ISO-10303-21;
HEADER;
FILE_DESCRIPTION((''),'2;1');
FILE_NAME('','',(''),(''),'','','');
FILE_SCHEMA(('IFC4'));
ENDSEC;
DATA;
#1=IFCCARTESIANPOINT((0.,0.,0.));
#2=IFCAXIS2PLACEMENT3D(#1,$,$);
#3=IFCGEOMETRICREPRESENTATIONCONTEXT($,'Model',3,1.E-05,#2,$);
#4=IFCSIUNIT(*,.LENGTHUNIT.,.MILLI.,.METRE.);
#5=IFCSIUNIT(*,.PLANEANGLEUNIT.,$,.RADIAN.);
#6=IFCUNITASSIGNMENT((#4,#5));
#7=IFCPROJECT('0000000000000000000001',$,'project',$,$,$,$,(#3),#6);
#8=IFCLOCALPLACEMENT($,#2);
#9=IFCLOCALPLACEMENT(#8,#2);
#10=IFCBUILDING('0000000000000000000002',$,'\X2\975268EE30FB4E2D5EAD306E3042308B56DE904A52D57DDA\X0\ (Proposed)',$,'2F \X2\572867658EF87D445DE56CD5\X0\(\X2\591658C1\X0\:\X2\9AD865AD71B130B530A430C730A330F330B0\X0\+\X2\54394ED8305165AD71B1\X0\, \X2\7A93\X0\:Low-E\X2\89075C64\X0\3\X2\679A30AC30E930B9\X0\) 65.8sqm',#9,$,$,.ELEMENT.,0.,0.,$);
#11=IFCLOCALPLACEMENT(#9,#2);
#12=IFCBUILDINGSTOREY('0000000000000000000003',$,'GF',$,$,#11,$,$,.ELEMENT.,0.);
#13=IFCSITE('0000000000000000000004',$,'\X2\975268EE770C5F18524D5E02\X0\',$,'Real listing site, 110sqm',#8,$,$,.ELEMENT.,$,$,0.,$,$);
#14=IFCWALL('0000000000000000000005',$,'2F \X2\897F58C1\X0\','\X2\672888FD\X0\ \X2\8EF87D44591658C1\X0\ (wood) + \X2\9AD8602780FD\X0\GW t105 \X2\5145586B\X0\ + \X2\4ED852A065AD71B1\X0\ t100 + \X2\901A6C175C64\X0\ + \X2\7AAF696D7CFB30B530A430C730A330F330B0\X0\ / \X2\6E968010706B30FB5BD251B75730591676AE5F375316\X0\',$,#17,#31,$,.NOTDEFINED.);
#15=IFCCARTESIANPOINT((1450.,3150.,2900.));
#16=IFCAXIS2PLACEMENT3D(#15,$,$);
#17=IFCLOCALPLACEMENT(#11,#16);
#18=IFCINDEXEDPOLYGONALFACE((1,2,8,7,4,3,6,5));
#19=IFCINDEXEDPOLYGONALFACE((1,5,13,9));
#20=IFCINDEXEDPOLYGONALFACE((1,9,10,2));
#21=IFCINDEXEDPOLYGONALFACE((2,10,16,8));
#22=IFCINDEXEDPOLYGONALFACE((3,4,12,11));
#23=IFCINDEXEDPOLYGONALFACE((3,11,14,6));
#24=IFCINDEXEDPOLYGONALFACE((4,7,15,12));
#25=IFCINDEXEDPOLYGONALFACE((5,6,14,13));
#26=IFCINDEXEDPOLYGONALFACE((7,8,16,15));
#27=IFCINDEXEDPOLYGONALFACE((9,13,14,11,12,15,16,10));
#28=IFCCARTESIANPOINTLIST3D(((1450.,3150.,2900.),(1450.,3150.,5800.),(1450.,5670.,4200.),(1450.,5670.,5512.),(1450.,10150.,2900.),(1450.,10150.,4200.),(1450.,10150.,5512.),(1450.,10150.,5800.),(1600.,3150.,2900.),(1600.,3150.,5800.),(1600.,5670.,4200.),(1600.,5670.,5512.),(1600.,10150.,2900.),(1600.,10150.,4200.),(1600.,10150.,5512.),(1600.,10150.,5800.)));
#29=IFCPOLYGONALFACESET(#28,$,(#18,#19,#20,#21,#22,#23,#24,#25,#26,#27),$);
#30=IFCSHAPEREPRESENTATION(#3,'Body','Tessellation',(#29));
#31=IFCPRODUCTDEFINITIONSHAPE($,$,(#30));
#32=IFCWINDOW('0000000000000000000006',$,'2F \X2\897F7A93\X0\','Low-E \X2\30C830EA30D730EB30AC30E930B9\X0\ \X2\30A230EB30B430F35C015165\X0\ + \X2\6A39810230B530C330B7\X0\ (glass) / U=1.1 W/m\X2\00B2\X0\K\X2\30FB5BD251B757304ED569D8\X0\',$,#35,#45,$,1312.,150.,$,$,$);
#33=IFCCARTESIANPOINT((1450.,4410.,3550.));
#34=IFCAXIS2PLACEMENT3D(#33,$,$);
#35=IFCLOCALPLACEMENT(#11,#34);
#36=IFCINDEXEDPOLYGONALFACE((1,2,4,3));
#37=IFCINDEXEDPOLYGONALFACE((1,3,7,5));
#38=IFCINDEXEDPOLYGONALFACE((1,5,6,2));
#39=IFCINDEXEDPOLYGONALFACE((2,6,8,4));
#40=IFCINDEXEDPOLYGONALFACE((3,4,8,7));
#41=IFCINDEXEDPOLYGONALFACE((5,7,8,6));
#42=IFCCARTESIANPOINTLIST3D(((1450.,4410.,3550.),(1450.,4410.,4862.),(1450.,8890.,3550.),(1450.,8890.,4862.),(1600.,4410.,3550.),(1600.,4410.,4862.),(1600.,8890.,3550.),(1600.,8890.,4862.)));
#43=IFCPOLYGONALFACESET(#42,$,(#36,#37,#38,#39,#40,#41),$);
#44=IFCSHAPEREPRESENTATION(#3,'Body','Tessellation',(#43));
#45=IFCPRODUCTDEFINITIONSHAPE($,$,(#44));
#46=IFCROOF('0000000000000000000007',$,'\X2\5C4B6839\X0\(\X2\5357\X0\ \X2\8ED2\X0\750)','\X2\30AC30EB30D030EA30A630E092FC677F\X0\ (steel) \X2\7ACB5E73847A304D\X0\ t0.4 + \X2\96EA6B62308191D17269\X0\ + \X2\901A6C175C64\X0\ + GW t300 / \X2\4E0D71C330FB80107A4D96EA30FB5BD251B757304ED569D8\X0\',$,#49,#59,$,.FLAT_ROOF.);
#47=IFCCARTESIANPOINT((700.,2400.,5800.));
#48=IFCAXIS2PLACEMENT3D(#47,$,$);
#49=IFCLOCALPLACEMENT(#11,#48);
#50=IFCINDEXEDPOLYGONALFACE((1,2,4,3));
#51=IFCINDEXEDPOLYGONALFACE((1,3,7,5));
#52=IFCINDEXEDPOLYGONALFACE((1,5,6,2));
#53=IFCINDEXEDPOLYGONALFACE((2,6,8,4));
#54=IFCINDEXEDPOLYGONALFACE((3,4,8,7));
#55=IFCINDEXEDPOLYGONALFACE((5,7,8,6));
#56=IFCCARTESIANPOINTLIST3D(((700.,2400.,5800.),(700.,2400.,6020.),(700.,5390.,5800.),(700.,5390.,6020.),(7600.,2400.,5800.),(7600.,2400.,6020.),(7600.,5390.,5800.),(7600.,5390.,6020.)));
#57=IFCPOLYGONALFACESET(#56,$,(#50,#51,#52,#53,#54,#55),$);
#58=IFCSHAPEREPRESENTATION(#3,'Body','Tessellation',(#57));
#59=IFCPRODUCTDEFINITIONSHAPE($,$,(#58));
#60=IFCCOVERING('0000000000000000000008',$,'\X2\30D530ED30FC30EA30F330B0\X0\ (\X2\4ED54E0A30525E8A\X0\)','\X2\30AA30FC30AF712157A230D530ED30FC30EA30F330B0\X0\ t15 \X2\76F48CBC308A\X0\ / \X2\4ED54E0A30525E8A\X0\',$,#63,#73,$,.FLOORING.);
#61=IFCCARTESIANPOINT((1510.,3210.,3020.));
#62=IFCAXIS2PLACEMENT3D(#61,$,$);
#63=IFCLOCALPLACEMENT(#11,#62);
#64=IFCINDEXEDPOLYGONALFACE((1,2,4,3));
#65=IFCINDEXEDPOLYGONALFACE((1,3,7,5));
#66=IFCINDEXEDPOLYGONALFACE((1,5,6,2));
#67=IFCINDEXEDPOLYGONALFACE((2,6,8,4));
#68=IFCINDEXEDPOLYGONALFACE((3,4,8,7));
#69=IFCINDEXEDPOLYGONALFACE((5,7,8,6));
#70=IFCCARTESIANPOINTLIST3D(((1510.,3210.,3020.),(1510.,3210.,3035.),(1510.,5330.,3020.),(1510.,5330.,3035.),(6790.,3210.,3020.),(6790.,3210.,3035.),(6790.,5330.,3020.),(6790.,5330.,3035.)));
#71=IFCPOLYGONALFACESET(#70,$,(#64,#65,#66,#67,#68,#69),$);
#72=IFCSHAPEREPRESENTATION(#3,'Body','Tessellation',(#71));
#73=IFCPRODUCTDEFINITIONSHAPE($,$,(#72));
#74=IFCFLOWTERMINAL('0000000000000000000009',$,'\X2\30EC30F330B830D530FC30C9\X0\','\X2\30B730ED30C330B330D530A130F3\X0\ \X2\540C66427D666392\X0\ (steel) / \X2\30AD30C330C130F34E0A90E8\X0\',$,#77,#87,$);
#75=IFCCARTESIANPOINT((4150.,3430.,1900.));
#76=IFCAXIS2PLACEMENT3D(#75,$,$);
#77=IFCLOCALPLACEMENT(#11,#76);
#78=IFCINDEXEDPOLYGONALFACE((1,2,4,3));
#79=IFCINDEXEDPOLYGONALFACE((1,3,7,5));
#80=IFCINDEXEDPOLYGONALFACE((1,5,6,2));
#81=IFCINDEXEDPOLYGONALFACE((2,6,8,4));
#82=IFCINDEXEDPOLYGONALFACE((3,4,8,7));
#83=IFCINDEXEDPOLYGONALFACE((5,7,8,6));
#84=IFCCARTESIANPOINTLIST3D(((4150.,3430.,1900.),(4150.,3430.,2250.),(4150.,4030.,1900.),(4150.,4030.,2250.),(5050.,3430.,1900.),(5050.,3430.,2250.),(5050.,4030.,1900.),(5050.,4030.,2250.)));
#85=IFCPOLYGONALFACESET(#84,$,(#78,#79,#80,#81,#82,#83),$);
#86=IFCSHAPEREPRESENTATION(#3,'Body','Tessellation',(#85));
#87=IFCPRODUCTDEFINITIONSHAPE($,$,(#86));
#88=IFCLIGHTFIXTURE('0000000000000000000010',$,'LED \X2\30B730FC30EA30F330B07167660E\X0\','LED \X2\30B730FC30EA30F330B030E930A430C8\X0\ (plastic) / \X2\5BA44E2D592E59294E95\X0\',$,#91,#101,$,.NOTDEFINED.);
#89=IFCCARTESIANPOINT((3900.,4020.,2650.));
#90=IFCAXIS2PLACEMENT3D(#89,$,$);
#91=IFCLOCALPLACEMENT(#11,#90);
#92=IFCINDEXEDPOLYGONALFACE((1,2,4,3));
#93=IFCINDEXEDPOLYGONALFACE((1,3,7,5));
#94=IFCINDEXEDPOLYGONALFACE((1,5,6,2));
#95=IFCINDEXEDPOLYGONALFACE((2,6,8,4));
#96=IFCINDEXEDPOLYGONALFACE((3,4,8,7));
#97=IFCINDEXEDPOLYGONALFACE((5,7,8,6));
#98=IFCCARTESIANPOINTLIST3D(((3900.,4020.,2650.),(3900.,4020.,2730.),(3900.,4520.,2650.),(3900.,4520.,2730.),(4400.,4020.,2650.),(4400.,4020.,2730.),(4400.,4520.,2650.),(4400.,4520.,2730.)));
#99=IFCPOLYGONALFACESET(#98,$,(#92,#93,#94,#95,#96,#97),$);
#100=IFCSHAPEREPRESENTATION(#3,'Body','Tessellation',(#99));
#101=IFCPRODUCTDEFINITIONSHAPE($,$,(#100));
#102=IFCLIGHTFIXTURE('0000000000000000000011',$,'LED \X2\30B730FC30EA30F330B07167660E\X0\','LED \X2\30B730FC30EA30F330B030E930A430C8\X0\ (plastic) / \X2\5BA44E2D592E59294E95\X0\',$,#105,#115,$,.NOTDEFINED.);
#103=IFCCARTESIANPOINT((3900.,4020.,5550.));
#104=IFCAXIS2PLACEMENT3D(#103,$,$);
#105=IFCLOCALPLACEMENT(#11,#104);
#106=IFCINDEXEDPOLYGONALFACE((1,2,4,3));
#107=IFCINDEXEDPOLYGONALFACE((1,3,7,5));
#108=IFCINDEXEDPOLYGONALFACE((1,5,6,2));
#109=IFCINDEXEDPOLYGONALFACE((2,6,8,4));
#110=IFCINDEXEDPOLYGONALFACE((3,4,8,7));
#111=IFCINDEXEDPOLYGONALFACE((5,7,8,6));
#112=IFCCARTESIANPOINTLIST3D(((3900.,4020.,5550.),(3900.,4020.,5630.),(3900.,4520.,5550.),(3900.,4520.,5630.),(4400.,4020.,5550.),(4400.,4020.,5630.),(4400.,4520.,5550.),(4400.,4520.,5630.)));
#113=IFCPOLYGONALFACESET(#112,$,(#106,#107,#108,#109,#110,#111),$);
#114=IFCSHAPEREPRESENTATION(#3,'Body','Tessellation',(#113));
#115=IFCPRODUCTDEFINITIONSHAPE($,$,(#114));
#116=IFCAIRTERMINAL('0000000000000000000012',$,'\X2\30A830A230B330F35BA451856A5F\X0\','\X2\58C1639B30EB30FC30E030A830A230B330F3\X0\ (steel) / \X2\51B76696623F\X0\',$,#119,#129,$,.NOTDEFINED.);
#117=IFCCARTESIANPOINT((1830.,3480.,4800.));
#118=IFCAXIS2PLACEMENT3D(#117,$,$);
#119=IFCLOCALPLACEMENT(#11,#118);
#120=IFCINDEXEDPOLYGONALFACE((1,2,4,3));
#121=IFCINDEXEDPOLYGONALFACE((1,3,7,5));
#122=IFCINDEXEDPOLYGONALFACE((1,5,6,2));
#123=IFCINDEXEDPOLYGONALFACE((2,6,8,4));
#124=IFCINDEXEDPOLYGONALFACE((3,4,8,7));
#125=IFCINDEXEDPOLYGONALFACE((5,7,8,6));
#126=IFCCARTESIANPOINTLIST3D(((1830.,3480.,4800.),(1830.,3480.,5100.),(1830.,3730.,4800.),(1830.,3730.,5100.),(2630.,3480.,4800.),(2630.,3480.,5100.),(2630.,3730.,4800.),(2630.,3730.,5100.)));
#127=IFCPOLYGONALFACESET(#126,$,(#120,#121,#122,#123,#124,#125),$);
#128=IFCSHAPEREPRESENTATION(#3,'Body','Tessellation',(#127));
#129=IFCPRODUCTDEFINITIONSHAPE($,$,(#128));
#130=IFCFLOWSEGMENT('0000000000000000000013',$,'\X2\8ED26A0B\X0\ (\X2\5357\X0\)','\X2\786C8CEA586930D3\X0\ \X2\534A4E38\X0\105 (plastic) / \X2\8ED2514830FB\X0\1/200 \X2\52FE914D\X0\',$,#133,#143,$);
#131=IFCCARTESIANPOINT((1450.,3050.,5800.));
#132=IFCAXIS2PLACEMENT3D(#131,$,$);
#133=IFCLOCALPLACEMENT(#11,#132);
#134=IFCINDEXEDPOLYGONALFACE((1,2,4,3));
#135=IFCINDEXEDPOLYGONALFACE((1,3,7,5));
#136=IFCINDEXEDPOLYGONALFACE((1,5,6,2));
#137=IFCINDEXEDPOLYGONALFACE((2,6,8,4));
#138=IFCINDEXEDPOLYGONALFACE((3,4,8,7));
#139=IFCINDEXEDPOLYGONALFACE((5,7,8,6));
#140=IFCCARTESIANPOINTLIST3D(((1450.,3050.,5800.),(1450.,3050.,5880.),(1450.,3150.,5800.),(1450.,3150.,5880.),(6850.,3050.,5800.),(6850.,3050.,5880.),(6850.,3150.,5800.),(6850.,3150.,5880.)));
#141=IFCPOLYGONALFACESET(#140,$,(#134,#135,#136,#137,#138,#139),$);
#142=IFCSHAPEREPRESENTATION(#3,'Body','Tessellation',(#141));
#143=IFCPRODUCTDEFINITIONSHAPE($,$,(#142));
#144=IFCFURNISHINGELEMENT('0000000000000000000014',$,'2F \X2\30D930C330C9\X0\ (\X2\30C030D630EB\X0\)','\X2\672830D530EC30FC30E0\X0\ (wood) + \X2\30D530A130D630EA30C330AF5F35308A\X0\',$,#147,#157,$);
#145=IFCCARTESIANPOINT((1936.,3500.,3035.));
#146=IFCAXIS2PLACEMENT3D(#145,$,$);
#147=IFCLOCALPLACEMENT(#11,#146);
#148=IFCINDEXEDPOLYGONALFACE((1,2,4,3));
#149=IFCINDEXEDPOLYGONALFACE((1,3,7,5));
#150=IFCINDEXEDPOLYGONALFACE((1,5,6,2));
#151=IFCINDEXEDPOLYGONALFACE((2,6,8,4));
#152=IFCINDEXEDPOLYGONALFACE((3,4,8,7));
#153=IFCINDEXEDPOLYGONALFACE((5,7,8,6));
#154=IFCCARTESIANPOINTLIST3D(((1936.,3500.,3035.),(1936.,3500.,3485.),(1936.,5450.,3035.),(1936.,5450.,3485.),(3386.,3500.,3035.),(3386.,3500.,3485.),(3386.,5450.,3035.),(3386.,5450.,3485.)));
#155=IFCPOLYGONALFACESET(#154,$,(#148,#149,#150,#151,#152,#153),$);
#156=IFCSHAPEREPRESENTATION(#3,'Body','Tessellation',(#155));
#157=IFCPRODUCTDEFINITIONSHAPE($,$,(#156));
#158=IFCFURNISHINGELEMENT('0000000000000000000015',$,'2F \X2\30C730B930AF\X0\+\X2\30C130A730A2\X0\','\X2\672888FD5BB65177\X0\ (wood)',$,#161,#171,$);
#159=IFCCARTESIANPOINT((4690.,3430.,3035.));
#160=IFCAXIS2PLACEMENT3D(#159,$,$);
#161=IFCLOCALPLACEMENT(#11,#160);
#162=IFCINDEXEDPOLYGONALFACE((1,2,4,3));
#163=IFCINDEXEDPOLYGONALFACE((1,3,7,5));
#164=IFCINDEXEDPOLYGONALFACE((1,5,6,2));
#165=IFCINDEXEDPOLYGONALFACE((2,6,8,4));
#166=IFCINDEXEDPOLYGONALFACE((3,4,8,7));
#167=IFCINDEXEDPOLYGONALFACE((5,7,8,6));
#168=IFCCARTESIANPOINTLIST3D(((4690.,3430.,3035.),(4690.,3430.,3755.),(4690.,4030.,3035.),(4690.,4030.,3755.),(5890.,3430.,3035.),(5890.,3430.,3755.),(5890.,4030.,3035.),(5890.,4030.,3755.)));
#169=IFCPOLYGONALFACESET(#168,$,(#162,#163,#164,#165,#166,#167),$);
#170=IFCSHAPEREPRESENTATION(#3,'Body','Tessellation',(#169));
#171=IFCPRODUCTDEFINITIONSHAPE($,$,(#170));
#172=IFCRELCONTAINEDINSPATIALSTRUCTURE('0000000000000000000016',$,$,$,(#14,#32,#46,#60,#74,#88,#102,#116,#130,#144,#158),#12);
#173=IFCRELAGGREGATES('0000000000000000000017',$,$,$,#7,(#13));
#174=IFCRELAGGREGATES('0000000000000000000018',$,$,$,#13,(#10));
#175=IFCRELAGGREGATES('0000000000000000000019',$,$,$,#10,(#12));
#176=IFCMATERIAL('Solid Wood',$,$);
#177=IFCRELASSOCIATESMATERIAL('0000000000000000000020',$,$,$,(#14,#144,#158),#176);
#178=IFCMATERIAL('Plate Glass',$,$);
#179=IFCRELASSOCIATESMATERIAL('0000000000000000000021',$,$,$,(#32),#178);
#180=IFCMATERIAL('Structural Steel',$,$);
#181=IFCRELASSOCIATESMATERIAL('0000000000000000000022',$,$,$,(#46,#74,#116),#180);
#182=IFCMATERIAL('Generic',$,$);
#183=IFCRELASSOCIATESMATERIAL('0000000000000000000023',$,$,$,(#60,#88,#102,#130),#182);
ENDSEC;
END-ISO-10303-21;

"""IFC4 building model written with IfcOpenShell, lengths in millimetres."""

from ifc_helpers import new_model, si_unit, frame, frame_2d, origin, place, context, project, spatial, rectangle, extrude, material, element, fill, save


model = new_model("IFC4")

# Units and contexts
model_context = context("Model", 3, precision=1e-05, world=origin())
ifc_project = project(units=[si_unit("LENGTHUNIT", "METRE", prefix="MILLI"), si_unit("PLANEANGLEUNIT", "RADIAN")], contexts=[model_context])

# Site, building, storey
site_placement = place(None, origin())
site = spatial("IfcSite", under=ifc_project, at=site_placement, Name="青森県弘前市", ObjectType="Real listing site, 110sqm", CompositionType="ELEMENT", RefElevation=0.0)
building_placement = place(site_placement, origin())
building = spatial("IfcBuilding", under=site, at=building_placement, Name="青森・中庭のある回遊動線 (Proposed)", ObjectType="2F 在来軸組工法(外壁:高断熱サイディング+吹付け断熱, 窓:Low-E複層3枚ガラス) 65.8sqm", CompositionType="ELEMENT", ElevationOfRefHeight=0.0, ElevationOfTerrain=0.0)
storey_placement = place(building_placement, origin())
storey = spatial("IfcBuildingStorey", under=building, at=storey_placement, Name="GF", CompositionType="ELEMENT", Elevation=0.0)

# Shared definitions
ifc_material_1 = material(Name="Solid Wood")

# Shared definitions
ifc_material_2 = material(Name="Plate Glass")

# Wall, opening, window
wall_1_placement = place(storey_placement, frame((1450.0, 3150.0, 2900.0)))
wall_1 = element("IfcWall", 1, at=wall_1_placement, inside=storey, material=ifc_material_1, Name="2F 西壁", Description="木製 軸組外壁 (wood) + 高性能GW t105 充填 + 付加断熱 t100 + 通気層 + 窯業系サイディング / 準耐火・寒冷地外皮強化", PredefinedType="NOTDEFINED", context=model_context, shape_type="SweptSolid", body=[
    extrude(rectangle(XDim=150.0, YDim=7000.0, at=frame_2d((75.0, 3500.0))), frame((1450.0, 3150.0, 2900.0)), (0.0, 0.0, 1.0), 2900.0),
])
opening_1_placement = place(storey_placement, frame((1450.0, 4410.0, 3550.0)))
opening_1 = element("IfcOpeningElement", 2, at=opening_1_placement, cuts=wall_1, PredefinedType="NOTDEFINED", context=model_context, shape_type="SweptSolid", body=[
    extrude(rectangle(XDim=150.0, YDim=4480.0, at=frame_2d((75.0, 2240.0))), frame((1450.0, 4410.0, 3550.0)), (0.0, 0.0, 1.0), 1312.0),
])
window_1_placement = place(storey_placement, frame((1450.0, 4410.0, 3550.0)))
window_1 = element("IfcWindow", 3, at=window_1_placement, inside=storey, material=ifc_material_2, Name="2F 西窓", Description="Low-E トリプルガラス アルゴン封入 + 樹脂サッシ (glass) / U=1.1 W/m²K・寒冷地仕様", OverallHeight=1312.0, OverallWidth=150.0, context=model_context, shape_type="SweptSolid", body=[
    extrude(rectangle(XDim=150.0, YDim=4480.0, at=frame_2d((75.0, 2240.0))), frame((1450.0, 4410.0, 3550.0)), (0.0, 0.0, 1.0), 1312.0),
])
fill(opening_1, window_1)

# Roof
ifc_material_3 = material(Name="Structural Steel")
for number, where, name in (
    (4, (700.0, 2400.0, 5800.0), "屋根(南 軒750)"),
):
    element("IfcRoof", number, at=place(storey_placement, frame(where)), inside=storey, material=ifc_material_3, Name=name, Description="ガルバリウム鋼板 (steel) 立平葺き t0.4 + 雪止め金物 + 通気層 + GW t300 / 不燃・耐積雪・寒冷地仕様", PredefinedType="FLAT_ROOF", context=model_context, shape_type="SweptSolid", body=[
        extrude(rectangle(XDim=6900.0, YDim=2990.0, at=frame_2d((3450.0, 1495.0))), frame((700.0, 2400.0, 5800.0)), (0.0, 0.0, 1.0), 220.0),
    ])

# Covering
ifc_material_4 = material(Name="Generic")
covering_placement = place(storey_placement, frame((1510.0, 3210.0, 3020.0)))
element("IfcCovering", 5, at=covering_placement, inside=storey, material=ifc_material_4, Name="フローリング (仕上げ床)", Description="オーク無垢フローリング t15 直貼り / 仕上げ床", PredefinedType="FLOORING", context=model_context, shape_type="SweptSolid", body=[
    extrude(rectangle(XDim=5280.0, YDim=2120.0, at=frame_2d((2640.0, 1060.0))), frame((1510.0, 3210.0, 3020.0)), (0.0, 0.0, 1.0), 15.0),
])

# Flow terminal
flow_terminal_placement = place(storey_placement, frame((4150.0, 3430.0, 1900.0)))
element("IfcFlowTerminal", 6, at=flow_terminal_placement, inside=storey, material=ifc_material_3, Name="レンジフード", Description="シロッコファン 同時給排 (steel) / キッチン上部", context=model_context, shape_type="SweptSolid", body=[
    extrude(rectangle(XDim=900.0, YDim=600.0, at=frame_2d((450.0, 300.0))), frame((4150.0, 3430.0, 1900.0)), (0.0, 0.0, 1.0), 350.0),
])

# Light fixtures
light_fixture_1_placement = place(storey_placement, frame((3900.0, 4020.0, 2650.0)))
element("IfcLightFixture", 7, at=light_fixture_1_placement, inside=storey, material=ifc_material_4, Name="LED シーリング照明", Description="LED シーリングライト (plastic) / 室中央天井", PredefinedType="NOTDEFINED", context=model_context, shape_type="SweptSolid", body=[
    extrude(rectangle(XDim=500.0, YDim=500.0, at=frame_2d((250.0, 250.0))), frame((3900.0, 4020.0, 2650.0)), (0.0, 0.0, 1.0), 80.0),
])
light_fixture_2_placement = place(storey_placement, frame((3900.0, 4020.0, 5550.0)))
element("IfcLightFixture", 8, at=light_fixture_2_placement, inside=storey, material=ifc_material_4, Name="LED シーリング照明", Description="LED シーリングライト (plastic) / 室中央天井", PredefinedType="NOTDEFINED", context=model_context, shape_type="SweptSolid", body=[
    extrude(rectangle(XDim=500.0, YDim=500.0, at=frame_2d((250.0, 250.0))), frame((3900.0, 4020.0, 5550.0)), (0.0, 0.0, 1.0), 80.0),
])

# Air terminal
air_terminal_placement = place(storey_placement, frame((1830.0, 3480.0, 4800.0)))
element("IfcAirTerminal", 9, at=air_terminal_placement, inside=storey, material=ifc_material_3, Name="エアコン室内機", Description="壁掛ルームエアコン (steel) / 冷暖房", PredefinedType="NOTDEFINED", context=model_context, shape_type="SweptSolid", body=[
    extrude(rectangle(XDim=800.0, YDim=250.0, at=frame_2d((400.0, 125.0))), frame((1830.0, 3480.0, 4800.0)), (0.0, 0.0, 1.0), 300.0),
])

# Flow segment
flow_segment_placement = place(storey_placement, frame((1450.0, 3050.0, 5800.0)))
element("IfcFlowSegment", 10, at=flow_segment_placement, inside=storey, material=ifc_material_4, Name="軒樋 (南)", Description="硬質塩ビ 半丸105 (plastic) / 軒先・1/200 勾配", context=model_context, shape_type="SweptSolid", body=[
    extrude(rectangle(XDim=5400.0, YDim=100.0, at=frame_2d((2700.0, 50.0))), frame((1450.0, 3050.0, 5800.0)), (0.0, 0.0, 1.0), 80.0),
])

# Furnishing elements
furnishing_1_placement = place(storey_placement, frame((1936.0, 3500.0, 3035.0)))
element("IfcFurnishingElement", 11, at=furnishing_1_placement, inside=storey, material=ifc_material_1, Name="2F ベッド (ダブル)", Description="木フレーム (wood) + ファブリック張り", context=model_context, shape_type="SweptSolid", body=[
    extrude(rectangle(XDim=1450.0, YDim=1950.0, at=frame_2d((725.0, 975.0))), frame((1936.0, 3500.0, 3035.0)), (0.0, 0.0, 1.0), 450.0),
])
furnishing_2_placement = place(storey_placement, frame((4690.0, 3430.0, 3035.0)))
element("IfcFurnishingElement", 12, at=furnishing_2_placement, inside=storey, material=ifc_material_1, Name="2F デスク+チェア", Description="木製家具 (wood)", context=model_context, shape_type="SweptSolid", body=[
    extrude(rectangle(XDim=1200.0, YDim=600.0, at=frame_2d((600.0, 300.0))), frame((4690.0, 3430.0, 3035.0)), (0.0, 0.0, 1.0), 720.0),
])

save(model, "model.ifc")
